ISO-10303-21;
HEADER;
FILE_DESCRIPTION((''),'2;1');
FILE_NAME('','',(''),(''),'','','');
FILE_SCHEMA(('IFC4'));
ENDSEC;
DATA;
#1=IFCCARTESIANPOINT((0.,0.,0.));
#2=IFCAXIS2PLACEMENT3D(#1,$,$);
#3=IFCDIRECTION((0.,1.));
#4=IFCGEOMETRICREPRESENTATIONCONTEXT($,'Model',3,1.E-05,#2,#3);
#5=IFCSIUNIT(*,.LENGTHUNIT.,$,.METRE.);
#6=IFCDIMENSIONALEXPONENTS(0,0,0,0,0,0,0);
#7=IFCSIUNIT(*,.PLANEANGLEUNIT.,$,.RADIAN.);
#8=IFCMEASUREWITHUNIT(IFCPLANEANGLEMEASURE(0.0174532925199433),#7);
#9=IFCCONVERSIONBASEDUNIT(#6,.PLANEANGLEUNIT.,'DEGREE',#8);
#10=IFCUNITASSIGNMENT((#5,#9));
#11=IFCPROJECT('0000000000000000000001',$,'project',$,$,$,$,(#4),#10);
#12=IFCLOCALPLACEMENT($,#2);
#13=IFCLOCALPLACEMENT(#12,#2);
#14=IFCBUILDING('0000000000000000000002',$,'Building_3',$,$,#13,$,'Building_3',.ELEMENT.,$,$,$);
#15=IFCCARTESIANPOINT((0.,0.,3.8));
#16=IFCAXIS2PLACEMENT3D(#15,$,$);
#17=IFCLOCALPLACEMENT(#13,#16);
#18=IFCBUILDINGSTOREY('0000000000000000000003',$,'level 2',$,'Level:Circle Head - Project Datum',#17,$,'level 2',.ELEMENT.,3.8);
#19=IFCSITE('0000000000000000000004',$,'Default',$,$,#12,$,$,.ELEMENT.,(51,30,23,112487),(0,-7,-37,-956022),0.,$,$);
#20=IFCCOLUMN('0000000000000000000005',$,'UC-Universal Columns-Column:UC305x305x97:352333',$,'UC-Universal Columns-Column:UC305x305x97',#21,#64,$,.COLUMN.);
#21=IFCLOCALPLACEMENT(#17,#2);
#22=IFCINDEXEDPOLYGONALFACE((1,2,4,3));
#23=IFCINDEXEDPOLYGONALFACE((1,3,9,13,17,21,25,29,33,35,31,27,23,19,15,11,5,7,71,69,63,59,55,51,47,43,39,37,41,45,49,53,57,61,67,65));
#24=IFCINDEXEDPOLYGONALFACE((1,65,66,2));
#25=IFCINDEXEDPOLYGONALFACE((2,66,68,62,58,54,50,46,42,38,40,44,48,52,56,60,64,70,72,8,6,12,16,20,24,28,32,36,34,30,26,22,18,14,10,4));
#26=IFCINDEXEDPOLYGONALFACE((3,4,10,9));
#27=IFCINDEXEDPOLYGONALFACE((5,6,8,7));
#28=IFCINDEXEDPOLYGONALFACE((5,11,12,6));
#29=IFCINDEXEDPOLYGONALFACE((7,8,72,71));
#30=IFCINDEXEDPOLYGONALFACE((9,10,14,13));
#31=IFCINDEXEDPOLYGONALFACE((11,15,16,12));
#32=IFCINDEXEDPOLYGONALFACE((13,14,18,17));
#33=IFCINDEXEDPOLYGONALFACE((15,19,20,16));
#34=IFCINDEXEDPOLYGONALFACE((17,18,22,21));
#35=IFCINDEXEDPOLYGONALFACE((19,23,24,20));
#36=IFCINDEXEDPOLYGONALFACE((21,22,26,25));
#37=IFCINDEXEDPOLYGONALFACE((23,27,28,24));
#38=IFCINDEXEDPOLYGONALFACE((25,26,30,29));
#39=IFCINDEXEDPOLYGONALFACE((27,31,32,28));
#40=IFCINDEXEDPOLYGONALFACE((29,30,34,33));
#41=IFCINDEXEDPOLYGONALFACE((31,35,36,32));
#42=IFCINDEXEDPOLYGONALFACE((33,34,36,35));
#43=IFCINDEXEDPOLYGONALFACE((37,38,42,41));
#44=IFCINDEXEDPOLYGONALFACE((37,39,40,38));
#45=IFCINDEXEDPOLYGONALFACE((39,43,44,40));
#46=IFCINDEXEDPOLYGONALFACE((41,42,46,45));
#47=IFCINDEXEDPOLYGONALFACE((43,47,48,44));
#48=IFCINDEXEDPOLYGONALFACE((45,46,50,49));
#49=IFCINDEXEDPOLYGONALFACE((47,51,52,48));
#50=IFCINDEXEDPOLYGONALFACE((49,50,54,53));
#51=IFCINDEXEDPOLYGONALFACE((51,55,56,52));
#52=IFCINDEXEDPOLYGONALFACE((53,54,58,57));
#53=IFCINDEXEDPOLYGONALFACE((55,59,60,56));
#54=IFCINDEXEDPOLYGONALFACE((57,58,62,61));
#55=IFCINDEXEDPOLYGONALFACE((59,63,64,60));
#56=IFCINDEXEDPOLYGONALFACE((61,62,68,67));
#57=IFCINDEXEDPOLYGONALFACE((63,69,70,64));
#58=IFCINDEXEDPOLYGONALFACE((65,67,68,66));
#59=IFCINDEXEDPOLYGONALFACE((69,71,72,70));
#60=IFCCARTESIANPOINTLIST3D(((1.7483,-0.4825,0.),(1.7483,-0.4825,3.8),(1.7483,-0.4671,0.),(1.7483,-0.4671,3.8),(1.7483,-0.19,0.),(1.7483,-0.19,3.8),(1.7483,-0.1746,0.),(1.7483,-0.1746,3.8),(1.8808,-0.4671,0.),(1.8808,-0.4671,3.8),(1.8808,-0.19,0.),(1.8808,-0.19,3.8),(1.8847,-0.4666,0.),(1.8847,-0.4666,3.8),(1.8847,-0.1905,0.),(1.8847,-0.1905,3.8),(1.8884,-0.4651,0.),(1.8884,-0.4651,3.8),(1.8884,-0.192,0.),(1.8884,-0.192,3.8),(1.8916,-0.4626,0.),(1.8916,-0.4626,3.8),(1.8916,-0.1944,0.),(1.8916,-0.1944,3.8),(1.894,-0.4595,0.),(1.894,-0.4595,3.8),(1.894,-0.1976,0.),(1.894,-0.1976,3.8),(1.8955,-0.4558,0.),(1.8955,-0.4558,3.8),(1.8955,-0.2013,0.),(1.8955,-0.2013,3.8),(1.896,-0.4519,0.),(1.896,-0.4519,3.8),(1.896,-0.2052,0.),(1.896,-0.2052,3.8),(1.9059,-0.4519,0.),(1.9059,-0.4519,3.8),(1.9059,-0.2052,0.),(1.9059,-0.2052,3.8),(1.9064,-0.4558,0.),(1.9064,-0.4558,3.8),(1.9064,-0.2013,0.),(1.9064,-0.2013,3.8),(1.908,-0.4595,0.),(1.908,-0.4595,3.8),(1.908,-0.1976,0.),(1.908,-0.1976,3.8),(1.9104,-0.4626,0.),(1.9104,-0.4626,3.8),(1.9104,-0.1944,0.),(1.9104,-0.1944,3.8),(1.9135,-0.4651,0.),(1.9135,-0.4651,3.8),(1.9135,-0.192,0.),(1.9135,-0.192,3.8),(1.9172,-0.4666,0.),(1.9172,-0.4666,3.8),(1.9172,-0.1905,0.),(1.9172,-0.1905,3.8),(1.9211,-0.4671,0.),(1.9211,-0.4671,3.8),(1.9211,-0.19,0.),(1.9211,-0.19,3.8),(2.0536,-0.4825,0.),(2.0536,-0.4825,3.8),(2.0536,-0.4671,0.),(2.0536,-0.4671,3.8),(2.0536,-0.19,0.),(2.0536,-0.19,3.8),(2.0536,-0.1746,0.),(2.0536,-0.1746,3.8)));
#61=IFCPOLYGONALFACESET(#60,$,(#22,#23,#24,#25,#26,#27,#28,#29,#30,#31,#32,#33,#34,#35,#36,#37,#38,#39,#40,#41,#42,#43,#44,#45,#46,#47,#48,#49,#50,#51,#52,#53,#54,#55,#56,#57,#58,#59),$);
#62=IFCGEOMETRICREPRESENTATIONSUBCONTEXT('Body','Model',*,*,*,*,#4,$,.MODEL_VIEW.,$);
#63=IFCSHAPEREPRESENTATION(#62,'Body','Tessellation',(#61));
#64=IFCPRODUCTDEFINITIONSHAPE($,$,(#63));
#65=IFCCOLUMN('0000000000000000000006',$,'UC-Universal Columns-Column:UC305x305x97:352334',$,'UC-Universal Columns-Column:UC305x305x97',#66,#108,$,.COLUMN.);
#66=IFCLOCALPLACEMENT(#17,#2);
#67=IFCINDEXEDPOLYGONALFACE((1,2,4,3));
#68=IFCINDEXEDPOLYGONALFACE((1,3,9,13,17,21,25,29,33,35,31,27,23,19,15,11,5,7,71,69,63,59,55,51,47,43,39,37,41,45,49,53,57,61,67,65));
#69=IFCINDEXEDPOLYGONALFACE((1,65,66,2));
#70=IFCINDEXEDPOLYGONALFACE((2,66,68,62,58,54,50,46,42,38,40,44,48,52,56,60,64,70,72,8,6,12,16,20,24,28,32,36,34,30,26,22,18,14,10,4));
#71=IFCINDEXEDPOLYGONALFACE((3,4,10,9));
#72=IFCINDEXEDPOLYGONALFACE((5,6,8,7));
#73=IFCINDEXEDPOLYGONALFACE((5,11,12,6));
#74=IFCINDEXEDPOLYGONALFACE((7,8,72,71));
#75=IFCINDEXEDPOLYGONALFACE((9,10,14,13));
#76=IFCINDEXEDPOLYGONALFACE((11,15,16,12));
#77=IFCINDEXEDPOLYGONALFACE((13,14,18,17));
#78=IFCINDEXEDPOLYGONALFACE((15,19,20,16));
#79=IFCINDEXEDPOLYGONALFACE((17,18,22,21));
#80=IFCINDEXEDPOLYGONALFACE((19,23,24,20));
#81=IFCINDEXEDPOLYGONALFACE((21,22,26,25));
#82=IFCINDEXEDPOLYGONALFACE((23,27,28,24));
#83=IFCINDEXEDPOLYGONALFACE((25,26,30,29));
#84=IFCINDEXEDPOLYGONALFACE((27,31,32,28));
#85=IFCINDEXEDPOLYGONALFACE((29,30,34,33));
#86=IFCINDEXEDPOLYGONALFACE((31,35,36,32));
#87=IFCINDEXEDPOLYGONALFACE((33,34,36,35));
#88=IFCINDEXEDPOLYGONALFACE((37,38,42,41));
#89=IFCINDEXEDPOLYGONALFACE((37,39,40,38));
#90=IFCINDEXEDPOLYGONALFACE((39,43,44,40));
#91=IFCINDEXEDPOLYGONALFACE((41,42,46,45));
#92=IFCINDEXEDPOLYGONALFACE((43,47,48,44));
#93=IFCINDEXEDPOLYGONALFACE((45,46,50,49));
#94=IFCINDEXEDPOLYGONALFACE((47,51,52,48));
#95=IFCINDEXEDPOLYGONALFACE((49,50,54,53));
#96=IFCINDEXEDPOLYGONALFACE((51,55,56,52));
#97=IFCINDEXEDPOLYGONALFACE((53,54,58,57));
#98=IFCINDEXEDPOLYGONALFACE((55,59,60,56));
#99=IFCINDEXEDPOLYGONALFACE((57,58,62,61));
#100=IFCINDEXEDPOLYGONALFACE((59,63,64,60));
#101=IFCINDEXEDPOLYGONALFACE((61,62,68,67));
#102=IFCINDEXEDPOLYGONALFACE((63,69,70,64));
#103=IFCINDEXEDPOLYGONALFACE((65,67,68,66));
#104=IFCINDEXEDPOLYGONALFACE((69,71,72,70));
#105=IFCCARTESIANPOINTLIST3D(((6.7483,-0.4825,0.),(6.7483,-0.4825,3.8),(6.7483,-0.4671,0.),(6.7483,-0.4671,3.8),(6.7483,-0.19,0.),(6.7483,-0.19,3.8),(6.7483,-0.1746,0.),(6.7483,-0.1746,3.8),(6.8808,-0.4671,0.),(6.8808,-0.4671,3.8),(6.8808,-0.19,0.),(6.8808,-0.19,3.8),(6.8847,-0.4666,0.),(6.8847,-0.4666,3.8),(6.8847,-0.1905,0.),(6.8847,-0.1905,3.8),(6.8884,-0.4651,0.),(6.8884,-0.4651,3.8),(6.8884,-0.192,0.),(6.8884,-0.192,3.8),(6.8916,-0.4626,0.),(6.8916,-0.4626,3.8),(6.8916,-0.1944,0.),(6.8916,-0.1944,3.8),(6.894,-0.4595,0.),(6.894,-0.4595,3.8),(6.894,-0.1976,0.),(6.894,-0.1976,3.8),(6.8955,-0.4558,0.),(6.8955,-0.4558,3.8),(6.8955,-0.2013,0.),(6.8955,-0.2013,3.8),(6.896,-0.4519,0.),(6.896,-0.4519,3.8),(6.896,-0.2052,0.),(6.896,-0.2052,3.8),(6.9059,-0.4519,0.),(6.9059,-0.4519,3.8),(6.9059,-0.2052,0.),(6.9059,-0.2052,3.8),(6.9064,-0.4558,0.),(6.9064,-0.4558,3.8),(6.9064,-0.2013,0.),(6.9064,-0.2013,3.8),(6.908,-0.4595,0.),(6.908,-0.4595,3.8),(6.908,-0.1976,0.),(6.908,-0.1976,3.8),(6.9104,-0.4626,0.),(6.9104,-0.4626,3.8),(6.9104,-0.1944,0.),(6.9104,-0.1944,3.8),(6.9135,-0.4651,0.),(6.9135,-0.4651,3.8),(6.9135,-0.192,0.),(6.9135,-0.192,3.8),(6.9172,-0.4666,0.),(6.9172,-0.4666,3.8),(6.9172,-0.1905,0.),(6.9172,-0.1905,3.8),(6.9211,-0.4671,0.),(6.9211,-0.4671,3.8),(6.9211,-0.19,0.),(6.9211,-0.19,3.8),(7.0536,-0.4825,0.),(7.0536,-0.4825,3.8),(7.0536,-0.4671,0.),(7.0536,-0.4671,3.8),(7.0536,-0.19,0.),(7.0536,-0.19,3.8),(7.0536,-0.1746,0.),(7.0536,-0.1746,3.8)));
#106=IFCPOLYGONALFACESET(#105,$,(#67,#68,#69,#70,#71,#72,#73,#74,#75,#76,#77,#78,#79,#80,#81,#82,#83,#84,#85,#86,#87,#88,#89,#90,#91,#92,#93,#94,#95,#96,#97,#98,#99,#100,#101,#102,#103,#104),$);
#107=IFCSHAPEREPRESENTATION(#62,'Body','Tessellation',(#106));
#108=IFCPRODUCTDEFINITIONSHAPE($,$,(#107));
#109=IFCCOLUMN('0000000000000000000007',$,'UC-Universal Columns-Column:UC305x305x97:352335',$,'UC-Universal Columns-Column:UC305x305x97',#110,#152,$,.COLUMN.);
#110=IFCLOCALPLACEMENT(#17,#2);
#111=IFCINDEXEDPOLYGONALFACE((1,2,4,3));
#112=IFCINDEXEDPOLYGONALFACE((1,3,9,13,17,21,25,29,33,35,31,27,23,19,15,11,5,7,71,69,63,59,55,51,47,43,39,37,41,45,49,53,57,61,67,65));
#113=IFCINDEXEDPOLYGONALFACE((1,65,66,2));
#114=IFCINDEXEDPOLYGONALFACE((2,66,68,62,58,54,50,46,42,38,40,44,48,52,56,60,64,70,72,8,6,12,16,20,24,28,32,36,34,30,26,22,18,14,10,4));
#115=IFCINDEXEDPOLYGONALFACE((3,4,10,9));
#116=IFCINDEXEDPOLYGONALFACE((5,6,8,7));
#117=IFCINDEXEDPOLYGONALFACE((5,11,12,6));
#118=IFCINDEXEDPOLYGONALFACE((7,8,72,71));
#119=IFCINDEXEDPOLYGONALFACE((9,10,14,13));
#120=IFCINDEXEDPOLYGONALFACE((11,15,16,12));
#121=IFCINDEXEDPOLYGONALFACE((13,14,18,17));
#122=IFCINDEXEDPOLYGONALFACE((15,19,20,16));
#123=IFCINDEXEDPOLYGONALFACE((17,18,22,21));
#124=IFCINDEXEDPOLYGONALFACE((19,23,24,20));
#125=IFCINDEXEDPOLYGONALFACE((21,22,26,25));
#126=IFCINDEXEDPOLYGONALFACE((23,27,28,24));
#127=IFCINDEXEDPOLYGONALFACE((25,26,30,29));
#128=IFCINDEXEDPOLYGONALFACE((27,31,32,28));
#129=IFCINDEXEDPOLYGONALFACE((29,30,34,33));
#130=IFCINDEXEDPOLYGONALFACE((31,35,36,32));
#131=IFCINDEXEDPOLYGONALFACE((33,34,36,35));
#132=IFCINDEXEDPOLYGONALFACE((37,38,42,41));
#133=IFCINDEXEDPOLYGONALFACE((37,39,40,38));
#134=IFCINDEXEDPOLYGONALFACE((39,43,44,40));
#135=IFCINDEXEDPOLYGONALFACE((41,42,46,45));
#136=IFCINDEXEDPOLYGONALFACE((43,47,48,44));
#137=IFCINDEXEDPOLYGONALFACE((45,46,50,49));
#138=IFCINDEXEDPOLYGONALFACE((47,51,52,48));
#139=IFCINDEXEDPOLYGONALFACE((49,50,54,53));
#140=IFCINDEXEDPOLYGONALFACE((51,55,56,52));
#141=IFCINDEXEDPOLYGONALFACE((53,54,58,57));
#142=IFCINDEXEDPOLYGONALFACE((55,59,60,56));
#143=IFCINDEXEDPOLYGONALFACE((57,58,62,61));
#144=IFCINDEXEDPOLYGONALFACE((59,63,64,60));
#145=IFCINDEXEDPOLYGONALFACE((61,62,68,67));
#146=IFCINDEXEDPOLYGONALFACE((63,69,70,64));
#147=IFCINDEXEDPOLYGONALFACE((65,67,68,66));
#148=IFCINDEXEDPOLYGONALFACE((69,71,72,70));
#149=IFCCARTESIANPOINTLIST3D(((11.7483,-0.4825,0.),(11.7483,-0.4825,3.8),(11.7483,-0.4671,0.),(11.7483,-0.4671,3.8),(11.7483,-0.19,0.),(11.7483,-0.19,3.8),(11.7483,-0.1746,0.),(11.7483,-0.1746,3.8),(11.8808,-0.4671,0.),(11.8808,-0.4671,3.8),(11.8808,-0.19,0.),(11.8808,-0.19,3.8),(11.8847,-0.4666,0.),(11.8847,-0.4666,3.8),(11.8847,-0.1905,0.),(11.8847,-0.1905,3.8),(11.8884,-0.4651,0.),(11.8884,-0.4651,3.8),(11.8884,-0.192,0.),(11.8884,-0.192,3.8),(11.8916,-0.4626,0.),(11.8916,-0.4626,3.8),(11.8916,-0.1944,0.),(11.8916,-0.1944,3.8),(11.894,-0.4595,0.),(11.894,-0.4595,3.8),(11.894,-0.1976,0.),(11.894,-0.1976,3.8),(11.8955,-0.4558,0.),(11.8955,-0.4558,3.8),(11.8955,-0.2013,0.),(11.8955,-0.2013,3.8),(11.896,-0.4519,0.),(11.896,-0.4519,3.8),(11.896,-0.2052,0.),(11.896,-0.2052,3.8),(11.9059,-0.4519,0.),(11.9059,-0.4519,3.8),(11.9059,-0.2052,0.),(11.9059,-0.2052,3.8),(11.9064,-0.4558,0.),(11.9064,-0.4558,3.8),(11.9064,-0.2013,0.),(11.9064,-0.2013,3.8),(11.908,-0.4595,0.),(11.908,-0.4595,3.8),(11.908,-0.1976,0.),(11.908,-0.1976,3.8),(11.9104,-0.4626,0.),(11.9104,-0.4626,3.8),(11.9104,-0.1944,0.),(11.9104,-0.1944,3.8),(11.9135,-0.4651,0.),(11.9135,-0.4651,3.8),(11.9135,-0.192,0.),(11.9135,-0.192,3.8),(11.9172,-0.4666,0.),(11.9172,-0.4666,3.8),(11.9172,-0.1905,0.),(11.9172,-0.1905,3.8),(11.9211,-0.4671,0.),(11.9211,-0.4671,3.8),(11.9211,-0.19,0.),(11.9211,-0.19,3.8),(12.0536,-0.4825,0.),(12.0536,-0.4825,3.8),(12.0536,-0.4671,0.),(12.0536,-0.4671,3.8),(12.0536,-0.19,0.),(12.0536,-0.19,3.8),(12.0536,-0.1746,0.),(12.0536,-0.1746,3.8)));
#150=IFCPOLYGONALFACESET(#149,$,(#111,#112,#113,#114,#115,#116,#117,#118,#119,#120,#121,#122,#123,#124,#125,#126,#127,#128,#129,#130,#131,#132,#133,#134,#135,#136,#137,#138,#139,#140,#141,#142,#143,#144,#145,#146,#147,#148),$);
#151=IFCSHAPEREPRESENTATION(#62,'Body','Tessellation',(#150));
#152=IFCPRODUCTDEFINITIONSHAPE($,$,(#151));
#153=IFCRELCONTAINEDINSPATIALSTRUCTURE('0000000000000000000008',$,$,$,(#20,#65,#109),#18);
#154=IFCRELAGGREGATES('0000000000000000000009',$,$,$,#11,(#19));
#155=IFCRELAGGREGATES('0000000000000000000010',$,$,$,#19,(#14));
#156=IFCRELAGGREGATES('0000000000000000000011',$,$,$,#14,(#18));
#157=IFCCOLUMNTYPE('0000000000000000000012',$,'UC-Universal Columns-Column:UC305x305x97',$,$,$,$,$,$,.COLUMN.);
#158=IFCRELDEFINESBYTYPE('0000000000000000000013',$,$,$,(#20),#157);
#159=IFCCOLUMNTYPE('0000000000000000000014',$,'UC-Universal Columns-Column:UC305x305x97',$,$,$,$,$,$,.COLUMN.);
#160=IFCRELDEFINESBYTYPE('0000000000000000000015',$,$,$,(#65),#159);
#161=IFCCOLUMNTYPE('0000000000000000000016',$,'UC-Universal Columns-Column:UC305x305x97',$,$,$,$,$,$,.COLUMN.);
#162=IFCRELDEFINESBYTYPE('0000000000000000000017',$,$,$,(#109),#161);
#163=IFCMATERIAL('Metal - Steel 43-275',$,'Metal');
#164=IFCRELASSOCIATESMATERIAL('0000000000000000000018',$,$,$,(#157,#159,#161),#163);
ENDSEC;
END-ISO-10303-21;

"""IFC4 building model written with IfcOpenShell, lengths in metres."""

from ifc_helpers import new_model, entity, si_unit, converted_unit, direction, frame, frame_2d, origin, place, context, subcontext, project, spatial, i_section, extrude, source, transform, mapped, material, material_profile, profile_set, type_object, type_shapes, element, save


model = new_model("IFC4")

# Units and contexts
model_context = context("Model", 3, precision=1e-05, world=origin(), true_north=direction((0.0, 1.0)))
body_context = subcontext(model_context, "Body", "Model", "MODEL_VIEW")
ifc_project = project(units=[si_unit("LENGTHUNIT", "METRE"), converted_unit("PLANEANGLEUNIT", "DEGREE", entity("IfcPlaneAngleMeasure", 0.0174532925199433), si_unit("PLANEANGLEUNIT", "RADIAN"), dimensions=[0, 0, 0, 0, 0, 0, 0])], contexts=[model_context])

# Site, building, storey
site_placement = place(None, origin())
site = spatial("IfcSite", under=ifc_project, at=site_placement, Name="Default", CompositionType="ELEMENT", RefLatitude=(51, 30, 23, 112487), RefLongitude=(0, -7, -37, -956022), RefElevation=0.0)
building_placement = place(site_placement, origin())
building = spatial("IfcBuilding", under=site, at=building_placement, Name="Building_3", LongName="Building_3", CompositionType="ELEMENT")
storey_placement = place(building_placement, frame((0.0, 0.0, 3.8)))
storey = spatial("IfcBuildingStorey", under=building, at=storey_placement, Name="level 2", ObjectType="Level:Circle Head - Project Datum", LongName="level 2", CompositionType="ELEMENT", Elevation=3.8)

# Columns
ifc_material_1 = material(Name="Metal - Steel 43-275", Category="Metal")
ifc_material_profile_1 = material_profile(ifc_material_1, i_section(OverallWidth=0.3053, OverallDepth=0.3079, WebThickness=0.0099, FlangeThickness=0.0154, FilletRadius=0.0152, at=frame_2d((0.0, 0.0), x_axis=(1.0, 0.0))), Name="UC305x305x97")
ifc_profile_set_1 = profile_set([ifc_material_profile_1], Name="UC305x305x97")
column_type_1 = type_object("IfcColumnType", Name="UC-Universal Columns-Column:UC305x305x97", PredefinedType="COLUMN", material=ifc_profile_set_1)
shared_shape_1 = source(origin(), body_context, "Body", "SweptSolid", [
    extrude(i_section(OverallWidth=0.3053, OverallDepth=0.3079, WebThickness=0.0099, FlangeThickness=0.0154, FilletRadius=0.0152, at=frame_2d((0.0, 0.0), x_axis=(1.0, 0.0))), frame((1.901, -0.3285, 3.8), z_axis=(0.0, 0.0, 1.0), x_axis=(-1.0, 0.0, 0.0)), (0.0, 0.0, 1.0), 3.8),
])
type_shapes(column_type_1, [shared_shape_1])
column_1_placement = place(storey_placement, frame((0.0, 0.0, -3.8)))
element("IfcColumn", 1, at=column_1_placement, inside=storey, type_object=column_type_1, Name="UC-Universal Columns-Column:UC305x305x97:352333", ObjectType="UC-Universal Columns-Column:UC305x305x97", PredefinedType="COLUMN", context=body_context, shape_type="MappedRepresentation", body=[
    mapped(shared_shape_1, transform((0.0, 0.0, 0.0), scale=1.0)),
])
column_type_2 = type_object("IfcColumnType", Name="UC-Universal Columns-Column:UC305x305x97", PredefinedType="COLUMN", material=ifc_profile_set_1)
shared_shape_2 = source(origin(), body_context, "Body", "SweptSolid", [
    extrude(i_section(OverallWidth=0.3053, OverallDepth=0.3079, WebThickness=0.0099, FlangeThickness=0.0154, FilletRadius=0.0152, at=frame_2d((0.0, 0.0), x_axis=(1.0, 0.0))), frame((6.901, -0.3285, 3.8), z_axis=(0.0, 0.0, 1.0), x_axis=(-1.0, 0.0, 0.0)), (0.0, 0.0, 1.0), 3.8),
])
type_shapes(column_type_2, [shared_shape_2])
column_2_placement = place(storey_placement, frame((0.0, 0.0, -3.8)))
element("IfcColumn", 2, at=column_2_placement, inside=storey, type_object=column_type_2, Name="UC-Universal Columns-Column:UC305x305x97:352334", ObjectType="UC-Universal Columns-Column:UC305x305x97", PredefinedType="COLUMN", context=body_context, shape_type="MappedRepresentation", body=[
    mapped(shared_shape_2, transform((0.0, 0.0, 0.0), scale=1.0)),
])
column_type_3 = type_object("IfcColumnType", Name="UC-Universal Columns-Column:UC305x305x97", PredefinedType="COLUMN", material=ifc_profile_set_1)
shared_shape_3 = source(origin(), body_context, "Body", "SweptSolid", [
    extrude(i_section(OverallWidth=0.3053, OverallDepth=0.3079, WebThickness=0.0099, FlangeThickness=0.0154, FilletRadius=0.0152, at=frame_2d((0.0, 0.0), x_axis=(1.0, 0.0))), frame((11.901, -0.3285, 3.8), z_axis=(0.0, 0.0, 1.0), x_axis=(-1.0, 0.0, 0.0)), (0.0, 0.0, 1.0), 3.8),
])
type_shapes(column_type_3, [shared_shape_3])
column_3_placement = place(storey_placement, frame((0.0, 0.0, -3.8)))
element("IfcColumn", 3, at=column_3_placement, inside=storey, type_object=column_type_3, Name="UC-Universal Columns-Column:UC305x305x97:352335", ObjectType="UC-Universal Columns-Column:UC305x305x97", PredefinedType="COLUMN", context=body_context, shape_type="MappedRepresentation", body=[
    mapped(shared_shape_3, transform((0.0, 0.0, 0.0), scale=1.0)),
])

save(model, "model.ifc")
